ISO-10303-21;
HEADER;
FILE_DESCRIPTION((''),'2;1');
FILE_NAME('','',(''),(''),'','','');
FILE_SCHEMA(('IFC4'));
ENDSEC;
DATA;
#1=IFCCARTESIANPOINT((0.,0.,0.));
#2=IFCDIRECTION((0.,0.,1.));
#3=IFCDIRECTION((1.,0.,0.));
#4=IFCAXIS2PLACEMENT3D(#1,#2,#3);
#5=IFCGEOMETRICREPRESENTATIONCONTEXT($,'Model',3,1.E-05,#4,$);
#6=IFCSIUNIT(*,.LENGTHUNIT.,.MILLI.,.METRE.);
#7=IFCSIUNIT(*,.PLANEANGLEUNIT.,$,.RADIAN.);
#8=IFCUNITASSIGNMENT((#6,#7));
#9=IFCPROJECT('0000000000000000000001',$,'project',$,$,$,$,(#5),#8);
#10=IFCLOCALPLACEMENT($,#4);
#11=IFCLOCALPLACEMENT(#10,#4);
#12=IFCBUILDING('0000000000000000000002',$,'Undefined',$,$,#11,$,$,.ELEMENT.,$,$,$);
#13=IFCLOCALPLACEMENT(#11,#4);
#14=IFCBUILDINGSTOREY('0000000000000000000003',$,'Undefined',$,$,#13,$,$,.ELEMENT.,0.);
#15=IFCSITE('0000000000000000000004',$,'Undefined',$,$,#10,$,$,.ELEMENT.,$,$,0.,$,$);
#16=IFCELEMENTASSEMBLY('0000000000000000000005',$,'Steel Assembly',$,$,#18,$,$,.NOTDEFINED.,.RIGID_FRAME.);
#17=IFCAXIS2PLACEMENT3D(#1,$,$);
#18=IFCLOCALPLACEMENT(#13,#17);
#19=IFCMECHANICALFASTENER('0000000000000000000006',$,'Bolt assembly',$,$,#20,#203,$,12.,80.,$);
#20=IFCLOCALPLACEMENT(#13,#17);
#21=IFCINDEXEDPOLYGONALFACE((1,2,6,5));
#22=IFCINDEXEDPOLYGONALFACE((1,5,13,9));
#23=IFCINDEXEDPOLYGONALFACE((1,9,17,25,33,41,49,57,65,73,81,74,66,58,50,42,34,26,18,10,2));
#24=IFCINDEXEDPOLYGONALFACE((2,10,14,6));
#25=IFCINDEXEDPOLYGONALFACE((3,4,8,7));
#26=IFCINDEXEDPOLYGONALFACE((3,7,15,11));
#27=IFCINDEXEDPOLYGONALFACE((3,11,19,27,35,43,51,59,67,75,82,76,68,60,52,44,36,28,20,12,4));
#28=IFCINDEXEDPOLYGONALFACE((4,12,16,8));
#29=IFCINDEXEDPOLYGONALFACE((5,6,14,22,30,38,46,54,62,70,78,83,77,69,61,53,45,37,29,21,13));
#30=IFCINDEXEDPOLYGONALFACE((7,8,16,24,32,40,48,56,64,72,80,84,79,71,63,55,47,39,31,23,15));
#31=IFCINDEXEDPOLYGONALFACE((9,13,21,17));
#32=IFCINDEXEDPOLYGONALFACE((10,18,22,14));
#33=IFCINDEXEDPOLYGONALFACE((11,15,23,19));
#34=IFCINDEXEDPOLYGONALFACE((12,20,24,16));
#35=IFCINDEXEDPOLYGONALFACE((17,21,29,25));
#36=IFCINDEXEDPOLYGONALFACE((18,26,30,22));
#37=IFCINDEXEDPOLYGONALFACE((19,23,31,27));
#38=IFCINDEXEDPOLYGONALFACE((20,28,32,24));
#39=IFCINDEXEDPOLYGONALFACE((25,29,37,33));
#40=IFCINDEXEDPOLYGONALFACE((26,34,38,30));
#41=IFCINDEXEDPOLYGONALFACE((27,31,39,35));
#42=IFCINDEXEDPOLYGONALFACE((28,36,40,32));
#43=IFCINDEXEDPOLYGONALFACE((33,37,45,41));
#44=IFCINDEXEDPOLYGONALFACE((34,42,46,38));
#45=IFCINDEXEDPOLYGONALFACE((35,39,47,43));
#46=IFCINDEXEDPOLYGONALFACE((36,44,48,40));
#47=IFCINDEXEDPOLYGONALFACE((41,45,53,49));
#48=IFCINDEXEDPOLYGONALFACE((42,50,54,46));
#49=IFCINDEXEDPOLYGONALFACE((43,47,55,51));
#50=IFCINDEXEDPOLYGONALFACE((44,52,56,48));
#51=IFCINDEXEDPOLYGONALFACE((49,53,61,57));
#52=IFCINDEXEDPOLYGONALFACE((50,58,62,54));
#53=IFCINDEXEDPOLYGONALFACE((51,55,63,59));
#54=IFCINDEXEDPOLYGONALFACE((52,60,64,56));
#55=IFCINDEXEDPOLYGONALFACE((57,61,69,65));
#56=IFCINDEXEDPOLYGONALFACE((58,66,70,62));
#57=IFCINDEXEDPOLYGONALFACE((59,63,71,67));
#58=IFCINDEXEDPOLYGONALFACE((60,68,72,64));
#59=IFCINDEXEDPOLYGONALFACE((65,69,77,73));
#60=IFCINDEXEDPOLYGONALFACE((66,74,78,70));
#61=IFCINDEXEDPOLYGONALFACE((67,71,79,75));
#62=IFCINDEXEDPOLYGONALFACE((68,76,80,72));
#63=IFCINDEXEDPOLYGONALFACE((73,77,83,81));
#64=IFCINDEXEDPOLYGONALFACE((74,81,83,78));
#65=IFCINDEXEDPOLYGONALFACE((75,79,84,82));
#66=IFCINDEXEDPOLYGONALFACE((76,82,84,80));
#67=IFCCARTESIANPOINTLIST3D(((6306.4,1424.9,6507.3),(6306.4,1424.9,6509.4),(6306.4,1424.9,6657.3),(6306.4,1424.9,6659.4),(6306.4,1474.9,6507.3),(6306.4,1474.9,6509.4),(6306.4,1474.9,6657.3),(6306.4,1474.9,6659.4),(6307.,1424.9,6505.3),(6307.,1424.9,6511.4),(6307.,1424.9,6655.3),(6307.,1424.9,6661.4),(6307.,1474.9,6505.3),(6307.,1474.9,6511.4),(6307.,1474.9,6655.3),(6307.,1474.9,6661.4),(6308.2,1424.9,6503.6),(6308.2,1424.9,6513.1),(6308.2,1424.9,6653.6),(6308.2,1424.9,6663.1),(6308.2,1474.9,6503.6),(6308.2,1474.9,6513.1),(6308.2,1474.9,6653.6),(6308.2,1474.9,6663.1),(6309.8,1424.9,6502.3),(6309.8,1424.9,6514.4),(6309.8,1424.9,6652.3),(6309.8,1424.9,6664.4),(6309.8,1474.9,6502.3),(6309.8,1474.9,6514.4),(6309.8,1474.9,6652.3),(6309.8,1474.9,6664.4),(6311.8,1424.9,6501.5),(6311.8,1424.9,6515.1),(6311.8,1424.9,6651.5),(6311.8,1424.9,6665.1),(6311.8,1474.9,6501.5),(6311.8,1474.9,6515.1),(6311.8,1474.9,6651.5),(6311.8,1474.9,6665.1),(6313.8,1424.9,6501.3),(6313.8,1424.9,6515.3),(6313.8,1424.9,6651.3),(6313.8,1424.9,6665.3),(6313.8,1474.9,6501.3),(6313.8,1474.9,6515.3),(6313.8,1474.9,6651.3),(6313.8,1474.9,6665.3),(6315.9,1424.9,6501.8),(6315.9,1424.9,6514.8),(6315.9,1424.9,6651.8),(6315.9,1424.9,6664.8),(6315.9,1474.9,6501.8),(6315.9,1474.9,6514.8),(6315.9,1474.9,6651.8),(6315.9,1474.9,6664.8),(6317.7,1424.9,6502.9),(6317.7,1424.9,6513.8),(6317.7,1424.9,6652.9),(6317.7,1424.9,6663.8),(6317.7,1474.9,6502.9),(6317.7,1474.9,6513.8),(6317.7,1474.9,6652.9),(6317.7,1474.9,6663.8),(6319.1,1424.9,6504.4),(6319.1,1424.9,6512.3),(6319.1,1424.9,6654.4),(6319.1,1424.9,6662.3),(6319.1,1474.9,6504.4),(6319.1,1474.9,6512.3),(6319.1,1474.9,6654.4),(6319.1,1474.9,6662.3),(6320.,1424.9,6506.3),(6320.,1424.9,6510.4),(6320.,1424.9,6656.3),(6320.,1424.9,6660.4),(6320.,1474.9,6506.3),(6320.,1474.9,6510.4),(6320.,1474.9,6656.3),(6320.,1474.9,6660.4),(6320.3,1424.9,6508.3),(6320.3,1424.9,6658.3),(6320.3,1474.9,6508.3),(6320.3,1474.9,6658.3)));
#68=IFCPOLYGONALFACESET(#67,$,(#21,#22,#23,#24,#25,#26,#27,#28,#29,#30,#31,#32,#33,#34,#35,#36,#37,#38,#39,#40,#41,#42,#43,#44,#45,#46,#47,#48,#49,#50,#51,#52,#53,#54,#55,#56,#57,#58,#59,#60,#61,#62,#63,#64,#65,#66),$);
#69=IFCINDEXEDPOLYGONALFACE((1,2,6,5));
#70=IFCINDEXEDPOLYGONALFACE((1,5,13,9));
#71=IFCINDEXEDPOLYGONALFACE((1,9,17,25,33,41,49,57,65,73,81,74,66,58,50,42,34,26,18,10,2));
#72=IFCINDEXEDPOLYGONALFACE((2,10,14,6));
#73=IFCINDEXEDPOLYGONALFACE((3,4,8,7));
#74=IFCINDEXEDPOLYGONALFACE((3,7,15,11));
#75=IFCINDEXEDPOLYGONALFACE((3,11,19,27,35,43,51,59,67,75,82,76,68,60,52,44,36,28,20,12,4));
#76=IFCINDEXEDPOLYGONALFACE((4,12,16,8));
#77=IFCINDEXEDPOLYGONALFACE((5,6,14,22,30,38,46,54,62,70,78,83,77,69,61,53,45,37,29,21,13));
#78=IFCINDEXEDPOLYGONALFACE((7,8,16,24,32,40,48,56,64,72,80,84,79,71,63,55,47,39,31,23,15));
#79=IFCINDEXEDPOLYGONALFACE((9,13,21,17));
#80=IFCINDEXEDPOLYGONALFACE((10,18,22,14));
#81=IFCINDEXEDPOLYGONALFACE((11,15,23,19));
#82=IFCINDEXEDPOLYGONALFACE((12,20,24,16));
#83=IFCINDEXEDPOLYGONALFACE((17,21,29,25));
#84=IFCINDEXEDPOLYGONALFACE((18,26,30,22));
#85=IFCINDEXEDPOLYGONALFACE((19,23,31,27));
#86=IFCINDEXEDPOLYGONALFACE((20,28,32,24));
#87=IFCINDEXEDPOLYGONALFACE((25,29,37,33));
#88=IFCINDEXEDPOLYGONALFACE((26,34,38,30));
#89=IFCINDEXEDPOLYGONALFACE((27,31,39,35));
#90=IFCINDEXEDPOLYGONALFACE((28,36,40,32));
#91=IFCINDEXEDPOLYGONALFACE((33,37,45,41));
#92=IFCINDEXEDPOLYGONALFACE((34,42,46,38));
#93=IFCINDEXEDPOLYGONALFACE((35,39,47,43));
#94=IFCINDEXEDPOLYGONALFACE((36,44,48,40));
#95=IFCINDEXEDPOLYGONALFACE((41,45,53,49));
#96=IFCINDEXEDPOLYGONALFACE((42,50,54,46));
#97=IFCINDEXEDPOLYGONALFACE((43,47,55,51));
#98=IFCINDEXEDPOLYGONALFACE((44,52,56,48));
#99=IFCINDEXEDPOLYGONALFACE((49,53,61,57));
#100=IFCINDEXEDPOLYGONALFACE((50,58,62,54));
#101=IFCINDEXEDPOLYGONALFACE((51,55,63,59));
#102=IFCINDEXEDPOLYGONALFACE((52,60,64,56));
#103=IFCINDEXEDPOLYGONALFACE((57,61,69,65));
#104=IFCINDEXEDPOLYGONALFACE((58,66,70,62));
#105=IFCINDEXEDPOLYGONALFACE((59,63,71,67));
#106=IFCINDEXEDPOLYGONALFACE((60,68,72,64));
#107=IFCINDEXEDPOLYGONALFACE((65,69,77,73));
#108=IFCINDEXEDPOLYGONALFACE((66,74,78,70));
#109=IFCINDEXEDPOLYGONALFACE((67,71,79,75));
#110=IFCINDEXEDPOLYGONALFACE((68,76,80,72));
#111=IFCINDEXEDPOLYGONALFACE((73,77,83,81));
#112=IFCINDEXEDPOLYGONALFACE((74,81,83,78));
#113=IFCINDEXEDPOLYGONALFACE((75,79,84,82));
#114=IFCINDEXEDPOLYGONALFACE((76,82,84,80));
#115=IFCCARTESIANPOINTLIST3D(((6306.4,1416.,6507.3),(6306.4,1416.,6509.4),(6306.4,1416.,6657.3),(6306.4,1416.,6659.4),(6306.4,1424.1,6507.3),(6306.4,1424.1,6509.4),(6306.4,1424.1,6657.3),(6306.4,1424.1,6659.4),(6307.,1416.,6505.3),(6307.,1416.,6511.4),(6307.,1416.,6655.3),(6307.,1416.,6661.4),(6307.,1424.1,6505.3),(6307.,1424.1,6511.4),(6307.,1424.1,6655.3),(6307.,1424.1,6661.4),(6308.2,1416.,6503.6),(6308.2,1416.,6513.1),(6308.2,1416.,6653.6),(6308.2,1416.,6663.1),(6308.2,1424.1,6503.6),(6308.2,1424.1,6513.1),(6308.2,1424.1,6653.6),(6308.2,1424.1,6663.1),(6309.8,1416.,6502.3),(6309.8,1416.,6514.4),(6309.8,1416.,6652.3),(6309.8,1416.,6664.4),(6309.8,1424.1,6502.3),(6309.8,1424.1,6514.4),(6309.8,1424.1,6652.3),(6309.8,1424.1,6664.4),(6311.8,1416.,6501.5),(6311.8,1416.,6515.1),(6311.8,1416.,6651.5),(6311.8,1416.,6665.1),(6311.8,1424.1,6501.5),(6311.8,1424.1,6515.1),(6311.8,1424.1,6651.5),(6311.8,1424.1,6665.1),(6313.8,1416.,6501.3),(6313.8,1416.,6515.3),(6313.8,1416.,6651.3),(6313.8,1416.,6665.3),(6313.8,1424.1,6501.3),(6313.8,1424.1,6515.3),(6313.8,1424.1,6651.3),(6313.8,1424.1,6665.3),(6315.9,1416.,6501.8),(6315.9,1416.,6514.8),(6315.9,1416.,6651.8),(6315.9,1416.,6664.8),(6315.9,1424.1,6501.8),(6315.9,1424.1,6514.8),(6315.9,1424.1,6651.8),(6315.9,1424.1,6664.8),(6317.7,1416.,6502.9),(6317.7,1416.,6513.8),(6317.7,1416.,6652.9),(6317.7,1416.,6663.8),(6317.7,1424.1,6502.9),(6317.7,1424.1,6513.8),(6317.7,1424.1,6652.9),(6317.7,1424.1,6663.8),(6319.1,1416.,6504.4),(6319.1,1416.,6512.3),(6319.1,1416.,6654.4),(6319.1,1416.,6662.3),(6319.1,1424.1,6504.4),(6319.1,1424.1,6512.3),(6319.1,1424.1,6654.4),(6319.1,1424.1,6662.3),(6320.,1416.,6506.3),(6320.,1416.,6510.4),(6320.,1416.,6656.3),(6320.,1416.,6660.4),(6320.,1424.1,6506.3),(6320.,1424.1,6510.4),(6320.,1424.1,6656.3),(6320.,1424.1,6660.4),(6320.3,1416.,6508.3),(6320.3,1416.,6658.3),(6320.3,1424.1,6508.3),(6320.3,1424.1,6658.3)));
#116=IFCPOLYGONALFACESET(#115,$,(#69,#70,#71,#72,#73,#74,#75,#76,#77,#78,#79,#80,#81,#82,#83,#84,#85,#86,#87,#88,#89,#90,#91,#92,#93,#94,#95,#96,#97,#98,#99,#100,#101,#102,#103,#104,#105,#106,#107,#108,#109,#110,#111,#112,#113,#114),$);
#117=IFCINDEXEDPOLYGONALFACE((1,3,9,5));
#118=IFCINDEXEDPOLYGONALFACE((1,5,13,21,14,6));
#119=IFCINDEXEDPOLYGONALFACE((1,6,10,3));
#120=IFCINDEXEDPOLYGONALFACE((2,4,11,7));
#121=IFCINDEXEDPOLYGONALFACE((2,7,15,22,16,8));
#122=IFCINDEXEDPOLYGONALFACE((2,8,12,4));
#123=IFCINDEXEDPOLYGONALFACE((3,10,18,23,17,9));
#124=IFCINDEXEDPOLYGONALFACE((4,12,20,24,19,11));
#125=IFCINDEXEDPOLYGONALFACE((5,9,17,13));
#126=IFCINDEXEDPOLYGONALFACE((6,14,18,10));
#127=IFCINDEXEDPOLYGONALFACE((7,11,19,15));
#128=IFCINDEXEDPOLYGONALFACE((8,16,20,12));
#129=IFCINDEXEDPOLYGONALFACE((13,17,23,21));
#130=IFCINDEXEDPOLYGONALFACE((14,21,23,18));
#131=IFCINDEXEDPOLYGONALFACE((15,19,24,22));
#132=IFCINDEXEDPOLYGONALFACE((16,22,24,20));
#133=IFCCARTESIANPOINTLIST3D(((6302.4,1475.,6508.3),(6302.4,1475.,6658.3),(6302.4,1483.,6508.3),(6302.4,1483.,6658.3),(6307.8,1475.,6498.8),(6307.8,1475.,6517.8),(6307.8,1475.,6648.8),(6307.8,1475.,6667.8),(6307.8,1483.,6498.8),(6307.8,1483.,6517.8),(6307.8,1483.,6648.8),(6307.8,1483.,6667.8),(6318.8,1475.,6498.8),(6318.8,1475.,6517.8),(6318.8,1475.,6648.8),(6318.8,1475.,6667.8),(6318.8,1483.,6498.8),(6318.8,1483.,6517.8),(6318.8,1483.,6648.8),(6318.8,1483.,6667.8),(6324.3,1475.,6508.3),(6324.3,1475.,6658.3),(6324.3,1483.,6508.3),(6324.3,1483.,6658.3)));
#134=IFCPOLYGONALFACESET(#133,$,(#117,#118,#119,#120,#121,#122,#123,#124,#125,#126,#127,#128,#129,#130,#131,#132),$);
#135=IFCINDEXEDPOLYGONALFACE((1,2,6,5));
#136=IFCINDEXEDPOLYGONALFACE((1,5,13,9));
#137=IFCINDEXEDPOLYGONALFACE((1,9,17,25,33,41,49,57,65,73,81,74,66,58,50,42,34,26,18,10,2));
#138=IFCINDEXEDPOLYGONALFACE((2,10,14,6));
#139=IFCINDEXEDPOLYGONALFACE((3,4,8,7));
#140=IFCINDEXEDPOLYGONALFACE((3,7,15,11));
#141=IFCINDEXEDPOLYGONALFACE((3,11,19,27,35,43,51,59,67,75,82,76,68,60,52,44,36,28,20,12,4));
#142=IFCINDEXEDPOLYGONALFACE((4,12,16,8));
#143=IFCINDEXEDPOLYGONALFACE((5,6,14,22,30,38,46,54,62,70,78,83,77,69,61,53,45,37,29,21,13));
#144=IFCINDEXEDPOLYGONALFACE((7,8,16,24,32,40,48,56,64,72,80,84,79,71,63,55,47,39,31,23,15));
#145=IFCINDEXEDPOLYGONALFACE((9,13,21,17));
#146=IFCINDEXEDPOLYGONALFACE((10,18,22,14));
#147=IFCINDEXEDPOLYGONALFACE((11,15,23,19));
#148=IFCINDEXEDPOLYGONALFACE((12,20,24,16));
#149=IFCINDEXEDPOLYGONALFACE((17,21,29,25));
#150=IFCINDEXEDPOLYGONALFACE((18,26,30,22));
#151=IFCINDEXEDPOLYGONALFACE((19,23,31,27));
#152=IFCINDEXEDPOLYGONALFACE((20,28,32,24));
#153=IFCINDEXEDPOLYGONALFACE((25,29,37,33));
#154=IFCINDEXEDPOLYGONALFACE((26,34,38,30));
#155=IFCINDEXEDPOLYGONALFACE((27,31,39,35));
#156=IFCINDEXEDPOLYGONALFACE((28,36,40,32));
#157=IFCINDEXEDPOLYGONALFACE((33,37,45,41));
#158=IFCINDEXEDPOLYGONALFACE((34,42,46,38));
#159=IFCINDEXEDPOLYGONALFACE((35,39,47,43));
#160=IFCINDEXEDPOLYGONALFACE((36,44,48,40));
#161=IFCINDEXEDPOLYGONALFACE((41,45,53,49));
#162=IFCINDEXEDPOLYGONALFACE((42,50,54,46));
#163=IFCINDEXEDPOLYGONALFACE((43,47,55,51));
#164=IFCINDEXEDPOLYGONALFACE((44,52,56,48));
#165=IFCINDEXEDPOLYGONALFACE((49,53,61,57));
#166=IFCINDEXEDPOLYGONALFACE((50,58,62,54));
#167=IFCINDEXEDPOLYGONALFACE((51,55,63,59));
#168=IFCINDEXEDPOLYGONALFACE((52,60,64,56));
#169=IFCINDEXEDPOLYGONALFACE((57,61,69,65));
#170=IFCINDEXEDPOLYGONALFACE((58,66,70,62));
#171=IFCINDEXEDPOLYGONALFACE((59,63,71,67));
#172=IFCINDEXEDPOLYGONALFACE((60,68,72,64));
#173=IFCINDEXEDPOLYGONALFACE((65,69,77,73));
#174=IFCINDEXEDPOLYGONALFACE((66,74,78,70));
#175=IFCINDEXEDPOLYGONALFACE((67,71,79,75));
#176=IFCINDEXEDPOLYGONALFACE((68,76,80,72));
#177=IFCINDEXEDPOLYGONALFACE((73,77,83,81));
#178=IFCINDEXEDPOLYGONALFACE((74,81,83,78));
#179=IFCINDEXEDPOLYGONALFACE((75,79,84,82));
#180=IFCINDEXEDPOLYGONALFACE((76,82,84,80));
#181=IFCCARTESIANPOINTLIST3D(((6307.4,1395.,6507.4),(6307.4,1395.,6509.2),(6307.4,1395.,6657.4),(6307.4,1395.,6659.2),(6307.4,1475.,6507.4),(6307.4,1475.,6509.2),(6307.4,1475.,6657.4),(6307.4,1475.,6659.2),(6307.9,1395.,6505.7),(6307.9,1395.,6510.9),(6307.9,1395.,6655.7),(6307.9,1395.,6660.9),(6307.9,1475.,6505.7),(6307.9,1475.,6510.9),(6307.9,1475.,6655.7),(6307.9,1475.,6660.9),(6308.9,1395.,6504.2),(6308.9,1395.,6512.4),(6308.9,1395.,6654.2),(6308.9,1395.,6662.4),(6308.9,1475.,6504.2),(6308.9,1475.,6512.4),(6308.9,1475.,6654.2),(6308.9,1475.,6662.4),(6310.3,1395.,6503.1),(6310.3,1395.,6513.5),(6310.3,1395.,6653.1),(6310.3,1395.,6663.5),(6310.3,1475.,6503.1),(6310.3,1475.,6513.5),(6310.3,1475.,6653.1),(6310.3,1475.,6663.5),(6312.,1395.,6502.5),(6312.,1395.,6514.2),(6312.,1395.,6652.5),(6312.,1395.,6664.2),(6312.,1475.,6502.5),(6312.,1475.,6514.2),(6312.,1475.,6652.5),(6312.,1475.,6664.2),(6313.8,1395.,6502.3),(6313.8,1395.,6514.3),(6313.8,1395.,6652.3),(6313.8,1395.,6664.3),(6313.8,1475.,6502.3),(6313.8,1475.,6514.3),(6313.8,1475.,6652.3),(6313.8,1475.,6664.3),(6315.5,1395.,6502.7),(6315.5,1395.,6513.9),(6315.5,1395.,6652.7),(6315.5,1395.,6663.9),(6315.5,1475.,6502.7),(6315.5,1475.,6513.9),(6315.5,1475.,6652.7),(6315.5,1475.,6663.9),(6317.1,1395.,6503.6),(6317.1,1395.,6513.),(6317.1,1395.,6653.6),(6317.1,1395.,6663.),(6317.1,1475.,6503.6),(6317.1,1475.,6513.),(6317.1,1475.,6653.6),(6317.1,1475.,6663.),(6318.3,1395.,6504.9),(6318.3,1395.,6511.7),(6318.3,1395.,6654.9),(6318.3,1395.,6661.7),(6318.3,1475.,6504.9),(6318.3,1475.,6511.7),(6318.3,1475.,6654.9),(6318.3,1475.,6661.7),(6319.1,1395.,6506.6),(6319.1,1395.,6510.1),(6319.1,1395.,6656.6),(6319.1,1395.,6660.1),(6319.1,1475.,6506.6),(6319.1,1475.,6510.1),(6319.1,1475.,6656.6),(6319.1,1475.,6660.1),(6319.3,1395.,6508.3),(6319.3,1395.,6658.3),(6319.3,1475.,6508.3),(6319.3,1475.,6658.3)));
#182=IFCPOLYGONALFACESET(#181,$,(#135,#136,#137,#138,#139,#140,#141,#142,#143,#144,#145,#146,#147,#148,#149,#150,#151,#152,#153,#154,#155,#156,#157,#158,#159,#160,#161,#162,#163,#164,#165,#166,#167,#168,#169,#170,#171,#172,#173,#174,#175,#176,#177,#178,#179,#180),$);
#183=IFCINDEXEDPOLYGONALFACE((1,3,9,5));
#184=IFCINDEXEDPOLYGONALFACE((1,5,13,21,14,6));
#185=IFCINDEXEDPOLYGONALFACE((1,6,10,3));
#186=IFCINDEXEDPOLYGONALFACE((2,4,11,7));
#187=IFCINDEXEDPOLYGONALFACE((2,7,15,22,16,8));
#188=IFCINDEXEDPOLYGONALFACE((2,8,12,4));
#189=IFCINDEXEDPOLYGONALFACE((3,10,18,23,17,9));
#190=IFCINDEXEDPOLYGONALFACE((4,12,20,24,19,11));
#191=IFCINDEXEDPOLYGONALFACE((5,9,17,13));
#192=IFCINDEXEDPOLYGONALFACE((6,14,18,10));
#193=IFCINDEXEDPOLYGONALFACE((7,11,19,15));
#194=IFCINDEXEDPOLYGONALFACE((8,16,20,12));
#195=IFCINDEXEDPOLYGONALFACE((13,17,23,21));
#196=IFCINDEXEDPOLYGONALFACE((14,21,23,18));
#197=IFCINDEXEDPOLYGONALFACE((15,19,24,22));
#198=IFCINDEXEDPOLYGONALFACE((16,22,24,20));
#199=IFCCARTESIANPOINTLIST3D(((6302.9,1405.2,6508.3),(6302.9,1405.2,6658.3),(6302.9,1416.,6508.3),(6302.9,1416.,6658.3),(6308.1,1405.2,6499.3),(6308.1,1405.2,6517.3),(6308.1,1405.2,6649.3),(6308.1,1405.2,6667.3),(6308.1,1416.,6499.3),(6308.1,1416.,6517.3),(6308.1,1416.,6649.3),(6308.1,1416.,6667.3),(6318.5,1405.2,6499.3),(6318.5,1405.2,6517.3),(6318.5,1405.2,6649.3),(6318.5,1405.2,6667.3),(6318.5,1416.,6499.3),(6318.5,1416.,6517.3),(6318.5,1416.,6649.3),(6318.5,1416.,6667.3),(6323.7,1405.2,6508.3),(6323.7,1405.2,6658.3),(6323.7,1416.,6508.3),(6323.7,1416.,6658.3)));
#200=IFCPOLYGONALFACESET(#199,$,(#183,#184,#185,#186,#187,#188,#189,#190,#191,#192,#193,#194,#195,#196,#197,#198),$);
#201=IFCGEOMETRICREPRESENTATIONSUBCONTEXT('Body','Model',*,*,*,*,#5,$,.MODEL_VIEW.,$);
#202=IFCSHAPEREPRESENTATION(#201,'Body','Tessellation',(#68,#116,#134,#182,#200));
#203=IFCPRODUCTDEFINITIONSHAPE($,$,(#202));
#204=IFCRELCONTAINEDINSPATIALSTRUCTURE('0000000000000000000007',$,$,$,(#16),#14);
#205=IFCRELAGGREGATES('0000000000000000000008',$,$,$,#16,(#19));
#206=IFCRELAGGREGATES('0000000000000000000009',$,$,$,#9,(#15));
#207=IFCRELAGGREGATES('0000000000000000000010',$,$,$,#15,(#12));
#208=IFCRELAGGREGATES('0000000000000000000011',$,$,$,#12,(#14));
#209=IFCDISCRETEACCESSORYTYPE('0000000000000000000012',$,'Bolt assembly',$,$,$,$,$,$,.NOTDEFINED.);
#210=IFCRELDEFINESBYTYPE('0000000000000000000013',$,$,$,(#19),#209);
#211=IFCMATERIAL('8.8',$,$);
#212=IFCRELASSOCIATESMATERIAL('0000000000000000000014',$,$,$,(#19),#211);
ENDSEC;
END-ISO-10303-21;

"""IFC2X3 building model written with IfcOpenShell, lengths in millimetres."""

from ifc_helpers import new_model, si_unit, frame, origin_with_axes, origin_2d_with_axis, place, context, subcontext, project, spatial, polyline, circle, outline, extrude, source, transform, mapped, material, type_object, element, aggregate, save


model = new_model("IFC2X3")

# Units and contexts
model_context = context("Model", 3, precision=1e-05, world=origin_with_axes())
body_context = subcontext(model_context, "Body", "Model", "MODEL_VIEW")
ifc_project = project(units=[si_unit("LENGTHUNIT", "METRE", prefix="MILLI"), si_unit("PLANEANGLEUNIT", "RADIAN")], contexts=[model_context])

# Site, building, storey
site_placement = place(None, origin_with_axes())
site = spatial("IfcSite", under=ifc_project, at=site_placement, Name="Undefined", CompositionType="ELEMENT", RefElevation=0.0)
building_placement = place(site_placement, origin_with_axes())
building = spatial("IfcBuilding", under=site, at=building_placement, Name="Undefined", CompositionType="ELEMENT")
storey_placement = place(building_placement, origin_with_axes())
storey = spatial("IfcBuildingStorey", under=building, at=storey_placement, Name="Undefined", CompositionType="ELEMENT", Elevation=0.0)

# Element assembly
assembly_1_placement = place(storey_placement, origin_with_axes())
assembly_1 = element("IfcElementAssembly", 1, at=assembly_1_placement, inside=storey, Name="Steel Assembly", AssemblyPlace="NOTDEFINED", PredefinedType="RIGID_FRAME")

# Mechanical fastener
ifc_material_1 = material(Name="8.8")
discrete_accessory_type_1 = type_object("IfcDiscreteAccessoryType", Name="Bolt assembly")
shared_shape_1 = source(origin_with_axes(), body_context, "Body", "SweptSolid", [
    extrude(circle(Radius=7.0, at=origin_2d_with_axis()), frame((0.0, -52.9, 0.0), z_axis=(0.0, 1.0, 0.0), x_axis=(1.0, 0.0, 0.0)), (0.0, 0.0, 1.0), 50.0),
    extrude(circle(Radius=7.0, at=origin_2d_with_axis()), frame((0.0, -2.1, 0.0), z_axis=(0.0, 1.0, 0.0), x_axis=(1.0, 0.0, 0.0)), (0.0, 0.0, 1.0), 8.1),
    extrude(outline(polyline([(11.0, 0.0), (5.5, 9.5), (-5.5, 9.5), (-11.0, 0.0), (-5.5, -9.5), (5.5, -9.5), (11.0, 0.0)])), frame((0.0, -61.0, 0.0), z_axis=(0.0, 1.0, 0.0), x_axis=(1.0, 0.0, 0.0)), (0.0, 0.0, 1.0), 8.0),
    extrude(circle(Radius=6.0, at=origin_2d_with_axis()), frame((0.0, -53.0, 0.0), z_axis=(0.0, 1.0, 0.0), x_axis=(1.0, 0.0, 0.0)), (0.0, 0.0, 1.0), 80.0),
    extrude(outline(polyline([(10.4, 0.0), (5.2, 9.0), (-5.2, 9.0), (-10.4, 0.0), (-5.2, -9.0), (5.2, -9.0), (10.4, 0.0)])), frame((0.0, 6.0, 0.0), z_axis=(0.0, 1.0, 0.0), x_axis=(1.0, 0.0, 0.0)), (0.0, 0.0, 1.0), 10.8),
])
mechanical_fastener_1_placement = place(assembly_1_placement, frame((6288.3, 1422.0, 6583.3), z_axis=(0.0, 0.0, -1.0), x_axis=(1.0, 0.0, 0.0)))
mechanical_fastener_1 = element("IfcMechanicalFastener", 2, at=mechanical_fastener_1_placement, type_object=discrete_accessory_type_1, material=ifc_material_1, Name="Bolt assembly", NominalDiameter=12.0, NominalLength=80.0, context=body_context, shape_type="MappedRepresentation", body=[
    mapped(shared_shape_1, transform((25.0, 0.0, -75.0))),
    mapped(shared_shape_1, transform((25.0, 0.0, 75.0))),
])
aggregate(assembly_1, [mechanical_fastener_1])

save(model, "model.ifc")
